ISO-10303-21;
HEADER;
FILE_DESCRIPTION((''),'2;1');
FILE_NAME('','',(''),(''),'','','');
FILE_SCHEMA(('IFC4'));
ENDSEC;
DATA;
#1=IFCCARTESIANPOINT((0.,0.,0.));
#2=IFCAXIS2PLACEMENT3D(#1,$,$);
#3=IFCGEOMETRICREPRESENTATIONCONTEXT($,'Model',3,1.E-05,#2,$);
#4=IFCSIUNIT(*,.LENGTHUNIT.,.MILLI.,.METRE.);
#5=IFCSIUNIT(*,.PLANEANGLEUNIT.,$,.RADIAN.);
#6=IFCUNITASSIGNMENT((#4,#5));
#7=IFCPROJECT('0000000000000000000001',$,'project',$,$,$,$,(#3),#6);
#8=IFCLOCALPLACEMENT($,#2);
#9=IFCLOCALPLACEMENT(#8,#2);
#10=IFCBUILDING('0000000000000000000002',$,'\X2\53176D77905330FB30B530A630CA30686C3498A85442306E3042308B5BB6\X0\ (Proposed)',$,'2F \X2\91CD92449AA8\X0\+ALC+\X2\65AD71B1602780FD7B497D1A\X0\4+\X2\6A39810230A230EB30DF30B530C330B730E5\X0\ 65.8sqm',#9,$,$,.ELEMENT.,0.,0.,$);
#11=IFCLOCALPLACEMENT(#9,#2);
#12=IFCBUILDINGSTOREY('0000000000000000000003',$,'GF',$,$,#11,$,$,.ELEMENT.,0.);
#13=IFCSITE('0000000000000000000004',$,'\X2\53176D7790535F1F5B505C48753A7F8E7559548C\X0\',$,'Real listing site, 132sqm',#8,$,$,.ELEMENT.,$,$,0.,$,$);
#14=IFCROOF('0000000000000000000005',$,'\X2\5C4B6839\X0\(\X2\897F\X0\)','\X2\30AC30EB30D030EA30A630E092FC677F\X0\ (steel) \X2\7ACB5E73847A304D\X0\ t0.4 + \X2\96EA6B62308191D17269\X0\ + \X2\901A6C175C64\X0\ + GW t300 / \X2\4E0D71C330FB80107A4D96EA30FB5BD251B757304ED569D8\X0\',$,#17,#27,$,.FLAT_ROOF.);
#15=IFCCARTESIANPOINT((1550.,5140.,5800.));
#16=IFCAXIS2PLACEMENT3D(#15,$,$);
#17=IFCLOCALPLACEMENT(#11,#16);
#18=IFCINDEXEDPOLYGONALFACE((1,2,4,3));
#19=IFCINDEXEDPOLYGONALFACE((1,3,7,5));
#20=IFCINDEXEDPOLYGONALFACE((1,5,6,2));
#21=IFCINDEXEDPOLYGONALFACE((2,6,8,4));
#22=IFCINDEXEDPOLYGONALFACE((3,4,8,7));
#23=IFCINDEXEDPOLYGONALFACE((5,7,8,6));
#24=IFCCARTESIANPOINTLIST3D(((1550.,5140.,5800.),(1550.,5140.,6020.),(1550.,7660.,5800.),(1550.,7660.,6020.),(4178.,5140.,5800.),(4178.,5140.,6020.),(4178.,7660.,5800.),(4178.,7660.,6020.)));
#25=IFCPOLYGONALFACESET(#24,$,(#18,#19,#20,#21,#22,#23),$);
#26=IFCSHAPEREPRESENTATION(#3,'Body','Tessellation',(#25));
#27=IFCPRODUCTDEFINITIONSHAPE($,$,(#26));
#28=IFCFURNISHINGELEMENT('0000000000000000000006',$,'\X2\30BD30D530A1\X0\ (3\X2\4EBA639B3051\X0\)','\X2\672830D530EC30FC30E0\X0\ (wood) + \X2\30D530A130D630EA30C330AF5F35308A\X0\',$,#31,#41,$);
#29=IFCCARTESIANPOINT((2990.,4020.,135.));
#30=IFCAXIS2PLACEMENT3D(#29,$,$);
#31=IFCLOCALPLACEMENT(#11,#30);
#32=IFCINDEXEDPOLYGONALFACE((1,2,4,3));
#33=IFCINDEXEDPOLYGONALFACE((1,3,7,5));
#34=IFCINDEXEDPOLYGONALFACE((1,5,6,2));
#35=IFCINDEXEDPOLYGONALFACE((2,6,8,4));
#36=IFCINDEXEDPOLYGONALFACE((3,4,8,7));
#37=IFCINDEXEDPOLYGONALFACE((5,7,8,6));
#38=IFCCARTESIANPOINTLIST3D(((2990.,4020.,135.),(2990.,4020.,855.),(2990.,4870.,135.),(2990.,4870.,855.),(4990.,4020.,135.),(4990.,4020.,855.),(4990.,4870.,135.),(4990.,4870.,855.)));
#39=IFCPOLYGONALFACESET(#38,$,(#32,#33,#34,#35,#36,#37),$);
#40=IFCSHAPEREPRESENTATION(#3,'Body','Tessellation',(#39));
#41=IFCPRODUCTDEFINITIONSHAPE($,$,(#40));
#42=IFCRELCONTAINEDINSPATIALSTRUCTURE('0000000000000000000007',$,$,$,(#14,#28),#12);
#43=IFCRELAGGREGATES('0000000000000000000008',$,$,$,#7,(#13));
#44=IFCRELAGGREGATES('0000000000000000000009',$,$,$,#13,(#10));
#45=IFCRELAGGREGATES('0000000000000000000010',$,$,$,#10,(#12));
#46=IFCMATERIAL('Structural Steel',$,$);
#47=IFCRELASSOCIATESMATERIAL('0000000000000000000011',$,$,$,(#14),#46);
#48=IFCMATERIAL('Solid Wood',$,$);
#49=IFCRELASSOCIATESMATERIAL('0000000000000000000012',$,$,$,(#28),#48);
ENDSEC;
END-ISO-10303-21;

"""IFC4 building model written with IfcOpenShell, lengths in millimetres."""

from ifc_helpers import new_model, si_unit, frame, frame_2d, origin, place, context, project, spatial, rectangle, extrude, material, element, save


model = new_model("IFC4")

# Units and contexts
model_context = context("Model", 3, precision=1e-05, world=origin())
ifc_project = project(units=[si_unit("LENGTHUNIT", "METRE", prefix="MILLI"), si_unit("PLANEANGLEUNIT", "RADIAN")], contexts=[model_context])

# Site, building, storey
site_placement = place(None, origin())
site = spatial("IfcSite", under=ifc_project, at=site_placement, Name="北海道弟子屈町美留和", ObjectType="Real listing site, 132sqm", CompositionType="ELEMENT", RefElevation=0.0)
building_placement = place(site_placement, origin())
building = spatial("IfcBuilding", under=site, at=building_placement, Name="北海道・サウナと水風呂のある家 (Proposed)", ObjectType="2F 重鉄骨+ALC+断熱性能等級4+樹脂アルミサッシュ 65.8sqm", CompositionType="ELEMENT", ElevationOfRefHeight=0.0, ElevationOfTerrain=0.0)
storey_placement = place(building_placement, origin())
storey = spatial("IfcBuildingStorey", under=building, at=storey_placement, Name="GF", CompositionType="ELEMENT", Elevation=0.0)

# Shared definitions
ifc_material_1 = material(Name="Solid Wood")

# Roof
ifc_material_2 = material(Name="Structural Steel")
for number, where, name in (
    (1, (1550.0, 5140.0, 5800.0), "屋根(西)"),
):
    element("IfcRoof", number, at=place(storey_placement, frame(where)), inside=storey, material=ifc_material_2, Name=name, Description="ガルバリウム鋼板 (steel) 立平葺き t0.4 + 雪止め金物 + 通気層 + GW t300 / 不燃・耐積雪・寒冷地仕様", PredefinedType="FLAT_ROOF", context=model_context, shape_type="SweptSolid", body=[
        extrude(rectangle(XDim=2628.0, YDim=2520.0, at=frame_2d((1314.0, 1260.0))), frame((1550.0, 5140.0, 5800.0)), (0.0, 0.0, 1.0), 220.0),
    ])

# Furnishing element
furnishing_placement = place(storey_placement, frame((2990.0, 4020.0, 135.0)))
element("IfcFurnishingElement", 2, at=furnishing_placement, inside=storey, material=ifc_material_1, Name="ソファ (3人掛け)", Description="木フレーム (wood) + ファブリック張り", context=model_context, shape_type="SweptSolid", body=[
    extrude(rectangle(XDim=2000.0, YDim=850.0, at=frame_2d((1000.0, 425.0))), frame((2990.0, 4020.0, 135.0)), (0.0, 0.0, 1.0), 720.0),
])

save(model, "model.ifc")
